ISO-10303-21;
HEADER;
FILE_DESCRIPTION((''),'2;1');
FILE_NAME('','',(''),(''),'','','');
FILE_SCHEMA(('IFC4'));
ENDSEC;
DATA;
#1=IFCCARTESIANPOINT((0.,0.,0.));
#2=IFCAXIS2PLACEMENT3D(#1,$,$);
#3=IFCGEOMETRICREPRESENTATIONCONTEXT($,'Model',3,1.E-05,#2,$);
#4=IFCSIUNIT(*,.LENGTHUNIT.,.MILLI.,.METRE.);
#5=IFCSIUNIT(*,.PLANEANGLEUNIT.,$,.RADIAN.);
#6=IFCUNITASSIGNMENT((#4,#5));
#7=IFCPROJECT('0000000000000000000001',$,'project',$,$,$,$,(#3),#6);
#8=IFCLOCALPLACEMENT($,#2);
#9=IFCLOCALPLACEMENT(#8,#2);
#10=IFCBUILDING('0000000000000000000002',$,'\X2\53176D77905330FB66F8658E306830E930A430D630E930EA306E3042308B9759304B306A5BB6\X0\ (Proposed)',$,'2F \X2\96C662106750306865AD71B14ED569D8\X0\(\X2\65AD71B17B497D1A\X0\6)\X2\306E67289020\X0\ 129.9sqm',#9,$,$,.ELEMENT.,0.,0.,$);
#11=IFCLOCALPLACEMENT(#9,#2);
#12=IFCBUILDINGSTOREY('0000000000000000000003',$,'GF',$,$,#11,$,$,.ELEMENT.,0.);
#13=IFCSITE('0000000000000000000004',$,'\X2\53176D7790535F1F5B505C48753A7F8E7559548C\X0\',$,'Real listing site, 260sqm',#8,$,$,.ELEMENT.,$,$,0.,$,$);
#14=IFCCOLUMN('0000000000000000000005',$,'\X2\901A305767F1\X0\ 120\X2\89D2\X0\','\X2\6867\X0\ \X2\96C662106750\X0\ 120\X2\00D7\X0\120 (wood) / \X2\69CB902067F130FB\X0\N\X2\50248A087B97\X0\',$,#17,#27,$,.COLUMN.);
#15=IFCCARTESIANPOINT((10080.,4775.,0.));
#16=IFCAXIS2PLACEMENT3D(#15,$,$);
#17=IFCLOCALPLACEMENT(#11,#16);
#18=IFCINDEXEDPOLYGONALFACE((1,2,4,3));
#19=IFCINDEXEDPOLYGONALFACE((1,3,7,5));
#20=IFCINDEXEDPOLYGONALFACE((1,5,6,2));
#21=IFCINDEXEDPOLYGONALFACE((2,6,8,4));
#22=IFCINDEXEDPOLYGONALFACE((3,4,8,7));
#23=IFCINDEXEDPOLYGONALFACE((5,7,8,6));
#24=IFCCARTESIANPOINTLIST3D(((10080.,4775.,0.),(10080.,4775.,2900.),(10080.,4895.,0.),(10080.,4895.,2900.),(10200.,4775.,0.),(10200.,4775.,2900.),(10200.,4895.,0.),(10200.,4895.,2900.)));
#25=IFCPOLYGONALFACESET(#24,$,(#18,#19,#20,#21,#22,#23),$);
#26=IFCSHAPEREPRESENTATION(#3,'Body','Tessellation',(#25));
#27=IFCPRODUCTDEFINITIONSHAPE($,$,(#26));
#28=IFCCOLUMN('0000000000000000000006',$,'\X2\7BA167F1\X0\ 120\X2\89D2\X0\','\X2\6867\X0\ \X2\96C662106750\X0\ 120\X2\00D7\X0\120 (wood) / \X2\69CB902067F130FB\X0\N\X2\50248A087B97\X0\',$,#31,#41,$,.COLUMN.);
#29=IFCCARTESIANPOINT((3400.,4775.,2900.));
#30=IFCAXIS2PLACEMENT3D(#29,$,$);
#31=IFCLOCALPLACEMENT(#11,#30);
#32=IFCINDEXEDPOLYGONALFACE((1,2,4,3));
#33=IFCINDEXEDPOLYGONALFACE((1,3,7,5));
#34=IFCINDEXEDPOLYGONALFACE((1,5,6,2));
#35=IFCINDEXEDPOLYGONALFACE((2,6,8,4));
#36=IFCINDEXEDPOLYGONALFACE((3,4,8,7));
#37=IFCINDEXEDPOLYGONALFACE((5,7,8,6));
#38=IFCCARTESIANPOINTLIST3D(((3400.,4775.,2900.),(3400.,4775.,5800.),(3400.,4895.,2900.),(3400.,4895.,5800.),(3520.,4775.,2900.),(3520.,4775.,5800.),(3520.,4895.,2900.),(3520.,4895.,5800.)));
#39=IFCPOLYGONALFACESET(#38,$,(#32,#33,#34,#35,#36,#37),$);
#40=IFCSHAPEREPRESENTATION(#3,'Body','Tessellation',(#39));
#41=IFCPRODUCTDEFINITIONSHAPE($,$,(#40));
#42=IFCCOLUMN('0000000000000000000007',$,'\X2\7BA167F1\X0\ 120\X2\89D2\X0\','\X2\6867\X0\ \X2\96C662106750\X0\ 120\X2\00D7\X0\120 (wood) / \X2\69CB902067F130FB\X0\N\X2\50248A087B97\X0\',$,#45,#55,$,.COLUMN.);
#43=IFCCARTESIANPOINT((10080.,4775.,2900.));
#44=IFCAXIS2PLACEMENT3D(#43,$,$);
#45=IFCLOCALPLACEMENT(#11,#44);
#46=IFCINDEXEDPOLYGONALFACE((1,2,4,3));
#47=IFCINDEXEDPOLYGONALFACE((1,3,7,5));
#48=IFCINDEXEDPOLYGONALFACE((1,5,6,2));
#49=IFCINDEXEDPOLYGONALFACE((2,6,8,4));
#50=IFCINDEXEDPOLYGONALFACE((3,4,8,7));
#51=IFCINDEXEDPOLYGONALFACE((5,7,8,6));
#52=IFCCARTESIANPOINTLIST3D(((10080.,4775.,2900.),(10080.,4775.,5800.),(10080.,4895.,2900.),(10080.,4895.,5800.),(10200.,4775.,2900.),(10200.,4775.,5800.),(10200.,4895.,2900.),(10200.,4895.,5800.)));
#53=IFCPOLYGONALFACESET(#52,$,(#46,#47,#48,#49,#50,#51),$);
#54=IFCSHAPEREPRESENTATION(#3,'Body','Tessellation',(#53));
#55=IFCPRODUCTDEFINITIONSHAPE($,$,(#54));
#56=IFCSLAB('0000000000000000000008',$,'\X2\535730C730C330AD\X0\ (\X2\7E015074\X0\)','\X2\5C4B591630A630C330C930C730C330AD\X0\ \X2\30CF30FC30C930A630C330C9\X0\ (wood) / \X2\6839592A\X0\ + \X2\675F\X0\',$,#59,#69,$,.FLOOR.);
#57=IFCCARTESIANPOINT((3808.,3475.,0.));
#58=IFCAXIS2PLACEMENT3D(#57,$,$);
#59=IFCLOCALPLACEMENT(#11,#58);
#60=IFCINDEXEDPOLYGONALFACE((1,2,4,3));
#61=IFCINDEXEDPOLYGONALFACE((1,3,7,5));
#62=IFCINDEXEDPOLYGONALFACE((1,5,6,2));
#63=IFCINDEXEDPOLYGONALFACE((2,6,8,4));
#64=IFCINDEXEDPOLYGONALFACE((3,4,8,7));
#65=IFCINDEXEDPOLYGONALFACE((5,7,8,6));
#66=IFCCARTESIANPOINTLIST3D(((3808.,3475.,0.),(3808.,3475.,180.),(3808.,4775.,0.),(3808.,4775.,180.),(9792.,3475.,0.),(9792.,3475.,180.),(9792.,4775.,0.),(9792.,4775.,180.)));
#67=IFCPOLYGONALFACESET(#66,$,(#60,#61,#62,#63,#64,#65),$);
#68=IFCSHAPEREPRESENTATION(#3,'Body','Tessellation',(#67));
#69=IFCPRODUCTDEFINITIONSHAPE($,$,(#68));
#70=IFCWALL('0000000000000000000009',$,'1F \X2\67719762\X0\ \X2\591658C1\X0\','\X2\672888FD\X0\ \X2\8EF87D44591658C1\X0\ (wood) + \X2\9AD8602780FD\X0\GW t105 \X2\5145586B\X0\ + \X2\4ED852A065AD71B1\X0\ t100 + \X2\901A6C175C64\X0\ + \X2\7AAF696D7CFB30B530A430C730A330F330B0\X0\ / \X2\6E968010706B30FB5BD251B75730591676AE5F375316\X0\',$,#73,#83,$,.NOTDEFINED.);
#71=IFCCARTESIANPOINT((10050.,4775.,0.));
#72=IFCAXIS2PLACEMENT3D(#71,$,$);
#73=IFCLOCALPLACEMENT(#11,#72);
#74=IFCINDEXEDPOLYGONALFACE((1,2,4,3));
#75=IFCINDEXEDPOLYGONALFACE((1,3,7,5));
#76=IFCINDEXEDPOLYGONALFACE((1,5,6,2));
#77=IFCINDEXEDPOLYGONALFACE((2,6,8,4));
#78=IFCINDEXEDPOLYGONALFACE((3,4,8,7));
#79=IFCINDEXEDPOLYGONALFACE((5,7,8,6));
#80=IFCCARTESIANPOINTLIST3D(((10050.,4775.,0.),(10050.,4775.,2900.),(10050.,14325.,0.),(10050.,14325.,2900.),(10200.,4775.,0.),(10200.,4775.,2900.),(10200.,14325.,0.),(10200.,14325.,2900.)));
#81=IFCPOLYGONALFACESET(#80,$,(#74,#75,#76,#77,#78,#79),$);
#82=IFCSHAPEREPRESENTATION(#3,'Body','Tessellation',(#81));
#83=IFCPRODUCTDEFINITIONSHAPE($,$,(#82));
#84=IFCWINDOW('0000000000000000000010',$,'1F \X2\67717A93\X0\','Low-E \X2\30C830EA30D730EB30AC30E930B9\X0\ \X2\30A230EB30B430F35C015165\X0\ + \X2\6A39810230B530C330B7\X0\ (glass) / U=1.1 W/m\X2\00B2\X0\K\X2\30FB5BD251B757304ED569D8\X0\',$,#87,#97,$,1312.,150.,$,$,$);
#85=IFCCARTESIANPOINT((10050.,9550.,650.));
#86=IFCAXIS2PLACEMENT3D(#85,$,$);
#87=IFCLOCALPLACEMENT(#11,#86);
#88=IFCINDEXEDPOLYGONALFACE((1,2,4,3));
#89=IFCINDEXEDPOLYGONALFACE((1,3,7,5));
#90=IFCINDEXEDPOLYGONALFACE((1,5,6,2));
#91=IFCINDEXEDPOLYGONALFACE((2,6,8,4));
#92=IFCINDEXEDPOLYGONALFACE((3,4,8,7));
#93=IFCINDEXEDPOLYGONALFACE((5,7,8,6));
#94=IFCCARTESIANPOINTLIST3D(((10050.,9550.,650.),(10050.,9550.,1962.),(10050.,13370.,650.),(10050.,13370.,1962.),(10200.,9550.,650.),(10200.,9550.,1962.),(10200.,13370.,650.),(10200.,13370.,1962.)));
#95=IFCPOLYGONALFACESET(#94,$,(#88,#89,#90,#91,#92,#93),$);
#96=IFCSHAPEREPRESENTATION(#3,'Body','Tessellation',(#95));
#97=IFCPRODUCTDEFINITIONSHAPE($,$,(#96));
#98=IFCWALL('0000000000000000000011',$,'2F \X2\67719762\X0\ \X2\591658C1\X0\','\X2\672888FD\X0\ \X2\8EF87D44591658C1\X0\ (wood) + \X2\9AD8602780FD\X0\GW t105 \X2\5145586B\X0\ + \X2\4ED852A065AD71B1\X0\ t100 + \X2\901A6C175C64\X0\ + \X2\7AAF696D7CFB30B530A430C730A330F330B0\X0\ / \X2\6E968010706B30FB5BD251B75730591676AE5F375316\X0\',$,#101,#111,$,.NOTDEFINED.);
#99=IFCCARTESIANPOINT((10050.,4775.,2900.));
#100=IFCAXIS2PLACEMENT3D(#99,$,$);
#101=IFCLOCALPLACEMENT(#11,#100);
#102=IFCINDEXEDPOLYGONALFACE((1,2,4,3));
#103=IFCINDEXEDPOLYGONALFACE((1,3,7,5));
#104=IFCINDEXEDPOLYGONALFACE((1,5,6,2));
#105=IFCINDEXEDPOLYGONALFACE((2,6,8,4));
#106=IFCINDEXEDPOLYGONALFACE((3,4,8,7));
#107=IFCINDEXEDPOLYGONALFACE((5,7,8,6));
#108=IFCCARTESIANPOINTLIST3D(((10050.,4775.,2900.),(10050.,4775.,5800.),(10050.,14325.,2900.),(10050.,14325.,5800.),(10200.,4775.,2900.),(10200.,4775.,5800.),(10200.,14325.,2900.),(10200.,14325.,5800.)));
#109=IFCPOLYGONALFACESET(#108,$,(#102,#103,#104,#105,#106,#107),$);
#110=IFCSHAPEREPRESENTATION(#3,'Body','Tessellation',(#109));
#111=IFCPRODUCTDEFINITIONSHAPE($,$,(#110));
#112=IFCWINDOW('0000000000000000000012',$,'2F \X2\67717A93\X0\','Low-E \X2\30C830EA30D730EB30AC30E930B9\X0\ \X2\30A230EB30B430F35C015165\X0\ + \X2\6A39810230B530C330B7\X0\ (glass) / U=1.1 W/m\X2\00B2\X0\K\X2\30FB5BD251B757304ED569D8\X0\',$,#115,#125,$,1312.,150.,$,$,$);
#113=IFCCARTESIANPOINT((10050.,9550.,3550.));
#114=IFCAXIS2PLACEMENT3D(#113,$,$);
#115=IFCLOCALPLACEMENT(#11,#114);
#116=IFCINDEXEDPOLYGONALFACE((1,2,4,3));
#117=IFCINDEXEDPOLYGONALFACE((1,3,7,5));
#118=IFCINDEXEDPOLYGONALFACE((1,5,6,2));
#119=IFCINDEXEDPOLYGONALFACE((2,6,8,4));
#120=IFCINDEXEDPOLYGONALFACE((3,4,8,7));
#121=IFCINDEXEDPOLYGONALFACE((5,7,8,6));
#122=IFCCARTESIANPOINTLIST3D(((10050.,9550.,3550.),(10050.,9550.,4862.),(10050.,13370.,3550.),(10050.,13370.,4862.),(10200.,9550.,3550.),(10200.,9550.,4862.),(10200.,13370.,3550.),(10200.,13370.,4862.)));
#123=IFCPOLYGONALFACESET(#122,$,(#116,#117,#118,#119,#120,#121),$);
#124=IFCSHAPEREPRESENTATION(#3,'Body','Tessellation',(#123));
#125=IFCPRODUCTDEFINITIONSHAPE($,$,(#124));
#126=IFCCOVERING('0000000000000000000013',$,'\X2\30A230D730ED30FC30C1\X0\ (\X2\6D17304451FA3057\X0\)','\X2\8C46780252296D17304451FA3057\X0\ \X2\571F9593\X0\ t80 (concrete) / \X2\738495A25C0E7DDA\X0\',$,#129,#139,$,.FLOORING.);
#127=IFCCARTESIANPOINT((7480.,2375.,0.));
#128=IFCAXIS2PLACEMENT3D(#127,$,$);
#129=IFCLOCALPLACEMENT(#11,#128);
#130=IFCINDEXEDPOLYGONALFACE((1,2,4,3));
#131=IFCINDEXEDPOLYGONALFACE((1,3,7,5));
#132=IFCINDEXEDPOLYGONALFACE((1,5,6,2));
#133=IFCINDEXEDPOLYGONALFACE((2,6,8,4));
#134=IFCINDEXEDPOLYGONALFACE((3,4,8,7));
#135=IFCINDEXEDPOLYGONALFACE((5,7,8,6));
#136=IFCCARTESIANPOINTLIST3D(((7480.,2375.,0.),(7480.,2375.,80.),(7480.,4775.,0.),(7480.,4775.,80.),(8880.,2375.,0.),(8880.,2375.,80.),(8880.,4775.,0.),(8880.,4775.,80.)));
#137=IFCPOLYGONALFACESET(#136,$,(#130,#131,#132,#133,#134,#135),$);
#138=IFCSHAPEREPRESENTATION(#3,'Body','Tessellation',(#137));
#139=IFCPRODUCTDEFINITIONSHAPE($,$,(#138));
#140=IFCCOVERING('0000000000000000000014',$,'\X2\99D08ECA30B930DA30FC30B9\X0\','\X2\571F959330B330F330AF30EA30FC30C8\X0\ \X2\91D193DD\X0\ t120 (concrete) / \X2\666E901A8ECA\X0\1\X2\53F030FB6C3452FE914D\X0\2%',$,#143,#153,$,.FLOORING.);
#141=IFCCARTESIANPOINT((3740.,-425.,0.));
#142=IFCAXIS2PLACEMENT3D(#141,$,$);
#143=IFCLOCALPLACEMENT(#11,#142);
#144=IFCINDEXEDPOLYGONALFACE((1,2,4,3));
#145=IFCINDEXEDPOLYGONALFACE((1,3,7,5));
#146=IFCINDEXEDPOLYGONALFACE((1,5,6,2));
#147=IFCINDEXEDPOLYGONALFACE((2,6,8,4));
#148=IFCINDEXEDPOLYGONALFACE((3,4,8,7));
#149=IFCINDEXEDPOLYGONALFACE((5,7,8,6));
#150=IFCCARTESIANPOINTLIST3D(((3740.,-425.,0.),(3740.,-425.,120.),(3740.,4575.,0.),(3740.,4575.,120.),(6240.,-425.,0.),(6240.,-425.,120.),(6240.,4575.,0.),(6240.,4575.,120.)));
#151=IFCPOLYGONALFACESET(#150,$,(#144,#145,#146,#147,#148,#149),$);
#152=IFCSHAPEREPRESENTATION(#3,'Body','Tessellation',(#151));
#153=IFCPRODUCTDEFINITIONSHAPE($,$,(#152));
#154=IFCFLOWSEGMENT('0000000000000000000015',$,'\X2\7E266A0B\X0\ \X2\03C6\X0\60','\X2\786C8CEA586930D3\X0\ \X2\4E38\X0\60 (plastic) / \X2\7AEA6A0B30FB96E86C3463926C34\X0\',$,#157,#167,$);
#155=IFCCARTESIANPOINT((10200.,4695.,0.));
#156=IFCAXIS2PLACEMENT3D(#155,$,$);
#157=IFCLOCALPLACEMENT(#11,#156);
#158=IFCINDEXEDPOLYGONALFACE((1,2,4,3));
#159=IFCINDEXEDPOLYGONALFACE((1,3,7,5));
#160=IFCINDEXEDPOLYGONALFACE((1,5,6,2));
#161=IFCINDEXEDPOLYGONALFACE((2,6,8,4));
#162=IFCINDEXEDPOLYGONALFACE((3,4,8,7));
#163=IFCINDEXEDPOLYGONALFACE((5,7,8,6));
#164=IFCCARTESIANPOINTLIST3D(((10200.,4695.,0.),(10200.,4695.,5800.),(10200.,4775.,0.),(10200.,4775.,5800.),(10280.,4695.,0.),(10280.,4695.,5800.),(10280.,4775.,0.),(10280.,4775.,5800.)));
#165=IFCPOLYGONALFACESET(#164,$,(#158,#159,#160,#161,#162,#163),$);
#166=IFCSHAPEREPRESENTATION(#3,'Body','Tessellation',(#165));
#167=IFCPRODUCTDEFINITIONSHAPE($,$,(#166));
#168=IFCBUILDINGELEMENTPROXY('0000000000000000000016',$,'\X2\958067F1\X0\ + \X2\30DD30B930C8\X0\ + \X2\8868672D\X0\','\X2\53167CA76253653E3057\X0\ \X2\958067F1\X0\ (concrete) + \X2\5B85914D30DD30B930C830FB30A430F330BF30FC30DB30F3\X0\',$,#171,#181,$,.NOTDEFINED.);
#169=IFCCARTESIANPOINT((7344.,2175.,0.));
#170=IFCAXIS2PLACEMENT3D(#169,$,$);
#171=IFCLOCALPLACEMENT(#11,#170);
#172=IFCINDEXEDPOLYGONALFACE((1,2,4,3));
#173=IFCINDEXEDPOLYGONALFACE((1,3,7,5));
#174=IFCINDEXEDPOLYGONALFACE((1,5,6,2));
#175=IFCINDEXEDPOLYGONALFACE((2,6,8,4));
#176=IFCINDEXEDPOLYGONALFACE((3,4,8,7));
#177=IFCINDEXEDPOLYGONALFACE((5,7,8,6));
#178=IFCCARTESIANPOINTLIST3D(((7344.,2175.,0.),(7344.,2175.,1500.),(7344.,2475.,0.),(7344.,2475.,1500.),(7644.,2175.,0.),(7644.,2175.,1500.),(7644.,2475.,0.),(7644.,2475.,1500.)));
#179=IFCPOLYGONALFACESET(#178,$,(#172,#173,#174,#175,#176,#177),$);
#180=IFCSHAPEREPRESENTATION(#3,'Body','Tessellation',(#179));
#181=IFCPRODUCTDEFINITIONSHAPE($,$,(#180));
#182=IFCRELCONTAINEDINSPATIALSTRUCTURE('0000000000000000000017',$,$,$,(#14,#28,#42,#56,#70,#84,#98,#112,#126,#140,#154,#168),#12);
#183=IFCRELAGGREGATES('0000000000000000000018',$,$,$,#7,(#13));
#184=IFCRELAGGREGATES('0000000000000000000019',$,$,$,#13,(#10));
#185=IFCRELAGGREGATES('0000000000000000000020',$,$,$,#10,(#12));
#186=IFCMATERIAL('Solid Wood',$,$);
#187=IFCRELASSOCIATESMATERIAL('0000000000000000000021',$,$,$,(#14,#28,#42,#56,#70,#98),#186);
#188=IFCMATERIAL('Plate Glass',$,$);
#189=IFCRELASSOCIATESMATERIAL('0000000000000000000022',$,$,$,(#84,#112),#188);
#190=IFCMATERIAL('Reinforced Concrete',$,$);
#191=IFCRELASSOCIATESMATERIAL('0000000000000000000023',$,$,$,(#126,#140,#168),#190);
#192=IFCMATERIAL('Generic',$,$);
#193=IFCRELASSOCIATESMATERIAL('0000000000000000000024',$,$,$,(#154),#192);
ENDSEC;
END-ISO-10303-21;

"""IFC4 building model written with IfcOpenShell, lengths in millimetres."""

from ifc_helpers import new_model, si_unit, frame, frame_2d, origin, place, context, project, spatial, rectangle, extrude, material, element, fill, save


model = new_model("IFC4")

# Units and contexts
model_context = context("Model", 3, precision=1e-05, world=origin())
ifc_project = project(units=[si_unit("LENGTHUNIT", "METRE", prefix="MILLI"), si_unit("PLANEANGLEUNIT", "RADIAN")], contexts=[model_context])

# Site, building, storey
site_placement = place(None, origin())
site = spatial("IfcSite", under=ifc_project, at=site_placement, Name="北海道弟子屈町美留和", ObjectType="Real listing site, 260sqm", CompositionType="ELEMENT", RefElevation=0.0)
building_placement = place(site_placement, origin())
building = spatial("IfcBuilding", under=site, at=building_placement, Name="北海道・書斎とライブラリのある静かな家 (Proposed)", ObjectType="2F 集成材と断熱仕様(断熱等級6)の木造 129.9sqm", CompositionType="ELEMENT", ElevationOfRefHeight=0.0, ElevationOfTerrain=0.0)
storey_placement = place(building_placement, origin())
storey = spatial("IfcBuildingStorey", under=building, at=storey_placement, Name="GF", CompositionType="ELEMENT", Elevation=0.0)

# Columns
ifc_material_1 = material(Name="Solid Wood")
column_1_placement = place(storey_placement, frame((10080.0, 4775.0, 0.0)))
element("IfcColumn", 1, at=column_1_placement, inside=storey, material=ifc_material_1, Name="通し柱 120角", Description="桧 集成材 120×120 (wood) / 構造柱・N値計算", PredefinedType="COLUMN", context=model_context, shape_type="SweptSolid", body=[
    extrude(rectangle(XDim=120.0, YDim=120.0, at=frame_2d((60.0, 60.0))), frame((10080.0, 4775.0, 0.0)), (0.0, 0.0, 1.0), 2900.0),
])
column_2_placement = place(storey_placement, frame((3400.0, 4775.0, 2900.0)))
element("IfcColumn", 2, at=column_2_placement, inside=storey, material=ifc_material_1, Name="管柱 120角", Description="桧 集成材 120×120 (wood) / 構造柱・N値計算", PredefinedType="COLUMN", context=model_context, shape_type="SweptSolid", body=[
    extrude(rectangle(XDim=120.0, YDim=120.0, at=frame_2d((60.0, 60.0))), frame((3400.0, 4775.0, 2900.0)), (0.0, 0.0, 1.0), 2900.0),
])
column_3_placement = place(storey_placement, frame((10080.0, 4775.0, 2900.0)))
element("IfcColumn", 3, at=column_3_placement, inside=storey, material=ifc_material_1, Name="管柱 120角", Description="桧 集成材 120×120 (wood) / 構造柱・N値計算", PredefinedType="COLUMN", context=model_context, shape_type="SweptSolid", body=[
    extrude(rectangle(XDim=120.0, YDim=120.0, at=frame_2d((60.0, 60.0))), frame((10080.0, 4775.0, 2900.0)), (0.0, 0.0, 1.0), 2900.0),
])

# Slab
slab_placement = place(storey_placement, frame((3808.0, 3475.0, 0.0)))
element("IfcSlab", 4, at=slab_placement, inside=storey, material=ifc_material_1, Name="南デッキ (縁側)", Description="屋外ウッドデッキ ハードウッド (wood) / 根太 + 束", PredefinedType="FLOOR", context=model_context, shape_type="SweptSolid", body=[
    extrude(rectangle(XDim=5984.0, YDim=1300.0, at=frame_2d((2992.0, 650.0))), frame((3808.0, 3475.0, 0.0)), (0.0, 0.0, 1.0), 180.0),
])

# Walls, openings, windows
wall_1_placement = place(storey_placement, frame((10050.0, 4775.0, 0.0)))
wall_1 = element("IfcWall", 5, at=wall_1_placement, inside=storey, material=ifc_material_1, Name="1F 東面 外壁", Description="木製 軸組外壁 (wood) + 高性能GW t105 充填 + 付加断熱 t100 + 通気層 + 窯業系サイディング / 準耐火・寒冷地外皮強化", PredefinedType="NOTDEFINED", context=model_context, shape_type="SweptSolid", body=[
    extrude(rectangle(XDim=150.0, YDim=9550.0, at=frame_2d((75.0, 4775.0))), frame((10050.0, 4775.0, 0.0)), (0.0, 0.0, 1.0), 2900.0),
])
opening_1_placement = place(storey_placement, frame((10050.0, 9550.0, 650.0)))
opening_1 = element("IfcOpeningElement", 6, at=opening_1_placement, cuts=wall_1, PredefinedType="NOTDEFINED", context=model_context, shape_type="SweptSolid", body=[
    extrude(rectangle(XDim=150.0, YDim=3820.0, at=frame_2d((75.0, 1910.0))), frame((10050.0, 9550.0, 650.0)), (0.0, 0.0, 1.0), 1312.0),
])
ifc_material_2 = material(Name="Plate Glass")
window_1_placement = place(storey_placement, frame((10050.0, 9550.0, 650.0)))
window_1 = element("IfcWindow", 7, at=window_1_placement, inside=storey, material=ifc_material_2, Name="1F 東窓", Description="Low-E トリプルガラス アルゴン封入 + 樹脂サッシ (glass) / U=1.1 W/m²K・寒冷地仕様", OverallHeight=1312.0, OverallWidth=150.0, context=model_context, shape_type="SweptSolid", body=[
    extrude(rectangle(XDim=150.0, YDim=3820.0, at=frame_2d((75.0, 1910.0))), frame((10050.0, 9550.0, 650.0)), (0.0, 0.0, 1.0), 1312.0),
])
fill(opening_1, window_1)
wall_2_placement = place(storey_placement, frame((10050.0, 4775.0, 2900.0)))
wall_2 = element("IfcWall", 8, at=wall_2_placement, inside=storey, material=ifc_material_1, Name="2F 東面 外壁", Description="木製 軸組外壁 (wood) + 高性能GW t105 充填 + 付加断熱 t100 + 通気層 + 窯業系サイディング / 準耐火・寒冷地外皮強化", PredefinedType="NOTDEFINED", context=model_context, shape_type="SweptSolid", body=[
    extrude(rectangle(XDim=150.0, YDim=9550.0, at=frame_2d((75.0, 4775.0))), frame((10050.0, 4775.0, 2900.0)), (0.0, 0.0, 1.0), 2900.0),
])
opening_2_placement = place(storey_placement, frame((10050.0, 9550.0, 3550.0)))
opening_2 = element("IfcOpeningElement", 9, at=opening_2_placement, cuts=wall_2, PredefinedType="NOTDEFINED", context=model_context, shape_type="SweptSolid", body=[
    extrude(rectangle(XDim=150.0, YDim=3820.0, at=frame_2d((75.0, 1910.0))), frame((10050.0, 9550.0, 3550.0)), (0.0, 0.0, 1.0), 1312.0),
])
window_2_placement = place(storey_placement, frame((10050.0, 9550.0, 3550.0)))
window_2 = element("IfcWindow", 10, at=window_2_placement, inside=storey, material=ifc_material_2, Name="2F 東窓", Description="Low-E トリプルガラス アルゴン封入 + 樹脂サッシ (glass) / U=1.1 W/m²K・寒冷地仕様", OverallHeight=1312.0, OverallWidth=150.0, context=model_context, shape_type="SweptSolid", body=[
    extrude(rectangle(XDim=150.0, YDim=3820.0, at=frame_2d((75.0, 1910.0))), frame((10050.0, 9550.0, 3550.0)), (0.0, 0.0, 1.0), 1312.0),
])
fill(opening_2, window_2)

# Coverings
ifc_material_3 = material(Name="Reinforced Concrete")
covering_1_placement = place(storey_placement, frame((7480.0, 2375.0, 0.0)))
element("IfcCovering", 11, at=covering_1_placement, inside=storey, material=ifc_material_3, Name="アプローチ (洗い出し)", Description="豆砂利洗い出し 土間 t80 (concrete) / 玄関導線", PredefinedType="FLOORING", context=model_context, shape_type="SweptSolid", body=[
    extrude(rectangle(XDim=1400.0, YDim=2400.0, at=frame_2d((700.0, 1200.0))), frame((7480.0, 2375.0, 0.0)), (0.0, 0.0, 1.0), 80.0),
])
covering_2_placement = place(storey_placement, frame((3740.0, -425.0, 0.0)))
element("IfcCovering", 12, at=covering_2_placement, inside=storey, material=ifc_material_3, Name="駐車スペース", Description="土間コンクリート 金鏝 t120 (concrete) / 普通車1台・水勾配2%", PredefinedType="FLOORING", context=model_context, shape_type="SweptSolid", body=[
    extrude(rectangle(XDim=2500.0, YDim=5000.0, at=frame_2d((1250.0, 2500.0))), frame((3740.0, -425.0, 0.0)), (0.0, 0.0, 1.0), 120.0),
])

# Flow segment
ifc_material_4 = material(Name="Generic")
flow_segment_placement = place(storey_placement, frame((10200.0, 4695.0, 0.0)))
element("IfcFlowSegment", 13, at=flow_segment_placement, inside=storey, material=ifc_material_4, Name="縦樋 φ60", Description="硬質塩ビ 丸60 (plastic) / 竪樋・雨水排水", context=model_context, shape_type="SweptSolid", body=[
    extrude(rectangle(XDim=80.0, YDim=80.0, at=frame_2d((40.0, 40.0))), frame((10200.0, 4695.0, 0.0)), (0.0, 0.0, 1.0), 5800.0),
])

# Building element proxy
proxy_placement = place(storey_placement, frame((7344.0, 2175.0, 0.0)))
element("IfcBuildingElementProxy", 14, at=proxy_placement, inside=storey, material=ifc_material_3, Name="門柱 + ポスト + 表札", Description="化粧打放し 門柱 (concrete) + 宅配ポスト・インターホン", PredefinedType="NOTDEFINED", context=model_context, shape_type="SweptSolid", body=[
    extrude(rectangle(XDim=300.0, YDim=300.0, at=frame_2d((150.0, 150.0))), frame((7344.0, 2175.0, 0.0)), (0.0, 0.0, 1.0), 1500.0),
])

save(model, "model.ifc")
